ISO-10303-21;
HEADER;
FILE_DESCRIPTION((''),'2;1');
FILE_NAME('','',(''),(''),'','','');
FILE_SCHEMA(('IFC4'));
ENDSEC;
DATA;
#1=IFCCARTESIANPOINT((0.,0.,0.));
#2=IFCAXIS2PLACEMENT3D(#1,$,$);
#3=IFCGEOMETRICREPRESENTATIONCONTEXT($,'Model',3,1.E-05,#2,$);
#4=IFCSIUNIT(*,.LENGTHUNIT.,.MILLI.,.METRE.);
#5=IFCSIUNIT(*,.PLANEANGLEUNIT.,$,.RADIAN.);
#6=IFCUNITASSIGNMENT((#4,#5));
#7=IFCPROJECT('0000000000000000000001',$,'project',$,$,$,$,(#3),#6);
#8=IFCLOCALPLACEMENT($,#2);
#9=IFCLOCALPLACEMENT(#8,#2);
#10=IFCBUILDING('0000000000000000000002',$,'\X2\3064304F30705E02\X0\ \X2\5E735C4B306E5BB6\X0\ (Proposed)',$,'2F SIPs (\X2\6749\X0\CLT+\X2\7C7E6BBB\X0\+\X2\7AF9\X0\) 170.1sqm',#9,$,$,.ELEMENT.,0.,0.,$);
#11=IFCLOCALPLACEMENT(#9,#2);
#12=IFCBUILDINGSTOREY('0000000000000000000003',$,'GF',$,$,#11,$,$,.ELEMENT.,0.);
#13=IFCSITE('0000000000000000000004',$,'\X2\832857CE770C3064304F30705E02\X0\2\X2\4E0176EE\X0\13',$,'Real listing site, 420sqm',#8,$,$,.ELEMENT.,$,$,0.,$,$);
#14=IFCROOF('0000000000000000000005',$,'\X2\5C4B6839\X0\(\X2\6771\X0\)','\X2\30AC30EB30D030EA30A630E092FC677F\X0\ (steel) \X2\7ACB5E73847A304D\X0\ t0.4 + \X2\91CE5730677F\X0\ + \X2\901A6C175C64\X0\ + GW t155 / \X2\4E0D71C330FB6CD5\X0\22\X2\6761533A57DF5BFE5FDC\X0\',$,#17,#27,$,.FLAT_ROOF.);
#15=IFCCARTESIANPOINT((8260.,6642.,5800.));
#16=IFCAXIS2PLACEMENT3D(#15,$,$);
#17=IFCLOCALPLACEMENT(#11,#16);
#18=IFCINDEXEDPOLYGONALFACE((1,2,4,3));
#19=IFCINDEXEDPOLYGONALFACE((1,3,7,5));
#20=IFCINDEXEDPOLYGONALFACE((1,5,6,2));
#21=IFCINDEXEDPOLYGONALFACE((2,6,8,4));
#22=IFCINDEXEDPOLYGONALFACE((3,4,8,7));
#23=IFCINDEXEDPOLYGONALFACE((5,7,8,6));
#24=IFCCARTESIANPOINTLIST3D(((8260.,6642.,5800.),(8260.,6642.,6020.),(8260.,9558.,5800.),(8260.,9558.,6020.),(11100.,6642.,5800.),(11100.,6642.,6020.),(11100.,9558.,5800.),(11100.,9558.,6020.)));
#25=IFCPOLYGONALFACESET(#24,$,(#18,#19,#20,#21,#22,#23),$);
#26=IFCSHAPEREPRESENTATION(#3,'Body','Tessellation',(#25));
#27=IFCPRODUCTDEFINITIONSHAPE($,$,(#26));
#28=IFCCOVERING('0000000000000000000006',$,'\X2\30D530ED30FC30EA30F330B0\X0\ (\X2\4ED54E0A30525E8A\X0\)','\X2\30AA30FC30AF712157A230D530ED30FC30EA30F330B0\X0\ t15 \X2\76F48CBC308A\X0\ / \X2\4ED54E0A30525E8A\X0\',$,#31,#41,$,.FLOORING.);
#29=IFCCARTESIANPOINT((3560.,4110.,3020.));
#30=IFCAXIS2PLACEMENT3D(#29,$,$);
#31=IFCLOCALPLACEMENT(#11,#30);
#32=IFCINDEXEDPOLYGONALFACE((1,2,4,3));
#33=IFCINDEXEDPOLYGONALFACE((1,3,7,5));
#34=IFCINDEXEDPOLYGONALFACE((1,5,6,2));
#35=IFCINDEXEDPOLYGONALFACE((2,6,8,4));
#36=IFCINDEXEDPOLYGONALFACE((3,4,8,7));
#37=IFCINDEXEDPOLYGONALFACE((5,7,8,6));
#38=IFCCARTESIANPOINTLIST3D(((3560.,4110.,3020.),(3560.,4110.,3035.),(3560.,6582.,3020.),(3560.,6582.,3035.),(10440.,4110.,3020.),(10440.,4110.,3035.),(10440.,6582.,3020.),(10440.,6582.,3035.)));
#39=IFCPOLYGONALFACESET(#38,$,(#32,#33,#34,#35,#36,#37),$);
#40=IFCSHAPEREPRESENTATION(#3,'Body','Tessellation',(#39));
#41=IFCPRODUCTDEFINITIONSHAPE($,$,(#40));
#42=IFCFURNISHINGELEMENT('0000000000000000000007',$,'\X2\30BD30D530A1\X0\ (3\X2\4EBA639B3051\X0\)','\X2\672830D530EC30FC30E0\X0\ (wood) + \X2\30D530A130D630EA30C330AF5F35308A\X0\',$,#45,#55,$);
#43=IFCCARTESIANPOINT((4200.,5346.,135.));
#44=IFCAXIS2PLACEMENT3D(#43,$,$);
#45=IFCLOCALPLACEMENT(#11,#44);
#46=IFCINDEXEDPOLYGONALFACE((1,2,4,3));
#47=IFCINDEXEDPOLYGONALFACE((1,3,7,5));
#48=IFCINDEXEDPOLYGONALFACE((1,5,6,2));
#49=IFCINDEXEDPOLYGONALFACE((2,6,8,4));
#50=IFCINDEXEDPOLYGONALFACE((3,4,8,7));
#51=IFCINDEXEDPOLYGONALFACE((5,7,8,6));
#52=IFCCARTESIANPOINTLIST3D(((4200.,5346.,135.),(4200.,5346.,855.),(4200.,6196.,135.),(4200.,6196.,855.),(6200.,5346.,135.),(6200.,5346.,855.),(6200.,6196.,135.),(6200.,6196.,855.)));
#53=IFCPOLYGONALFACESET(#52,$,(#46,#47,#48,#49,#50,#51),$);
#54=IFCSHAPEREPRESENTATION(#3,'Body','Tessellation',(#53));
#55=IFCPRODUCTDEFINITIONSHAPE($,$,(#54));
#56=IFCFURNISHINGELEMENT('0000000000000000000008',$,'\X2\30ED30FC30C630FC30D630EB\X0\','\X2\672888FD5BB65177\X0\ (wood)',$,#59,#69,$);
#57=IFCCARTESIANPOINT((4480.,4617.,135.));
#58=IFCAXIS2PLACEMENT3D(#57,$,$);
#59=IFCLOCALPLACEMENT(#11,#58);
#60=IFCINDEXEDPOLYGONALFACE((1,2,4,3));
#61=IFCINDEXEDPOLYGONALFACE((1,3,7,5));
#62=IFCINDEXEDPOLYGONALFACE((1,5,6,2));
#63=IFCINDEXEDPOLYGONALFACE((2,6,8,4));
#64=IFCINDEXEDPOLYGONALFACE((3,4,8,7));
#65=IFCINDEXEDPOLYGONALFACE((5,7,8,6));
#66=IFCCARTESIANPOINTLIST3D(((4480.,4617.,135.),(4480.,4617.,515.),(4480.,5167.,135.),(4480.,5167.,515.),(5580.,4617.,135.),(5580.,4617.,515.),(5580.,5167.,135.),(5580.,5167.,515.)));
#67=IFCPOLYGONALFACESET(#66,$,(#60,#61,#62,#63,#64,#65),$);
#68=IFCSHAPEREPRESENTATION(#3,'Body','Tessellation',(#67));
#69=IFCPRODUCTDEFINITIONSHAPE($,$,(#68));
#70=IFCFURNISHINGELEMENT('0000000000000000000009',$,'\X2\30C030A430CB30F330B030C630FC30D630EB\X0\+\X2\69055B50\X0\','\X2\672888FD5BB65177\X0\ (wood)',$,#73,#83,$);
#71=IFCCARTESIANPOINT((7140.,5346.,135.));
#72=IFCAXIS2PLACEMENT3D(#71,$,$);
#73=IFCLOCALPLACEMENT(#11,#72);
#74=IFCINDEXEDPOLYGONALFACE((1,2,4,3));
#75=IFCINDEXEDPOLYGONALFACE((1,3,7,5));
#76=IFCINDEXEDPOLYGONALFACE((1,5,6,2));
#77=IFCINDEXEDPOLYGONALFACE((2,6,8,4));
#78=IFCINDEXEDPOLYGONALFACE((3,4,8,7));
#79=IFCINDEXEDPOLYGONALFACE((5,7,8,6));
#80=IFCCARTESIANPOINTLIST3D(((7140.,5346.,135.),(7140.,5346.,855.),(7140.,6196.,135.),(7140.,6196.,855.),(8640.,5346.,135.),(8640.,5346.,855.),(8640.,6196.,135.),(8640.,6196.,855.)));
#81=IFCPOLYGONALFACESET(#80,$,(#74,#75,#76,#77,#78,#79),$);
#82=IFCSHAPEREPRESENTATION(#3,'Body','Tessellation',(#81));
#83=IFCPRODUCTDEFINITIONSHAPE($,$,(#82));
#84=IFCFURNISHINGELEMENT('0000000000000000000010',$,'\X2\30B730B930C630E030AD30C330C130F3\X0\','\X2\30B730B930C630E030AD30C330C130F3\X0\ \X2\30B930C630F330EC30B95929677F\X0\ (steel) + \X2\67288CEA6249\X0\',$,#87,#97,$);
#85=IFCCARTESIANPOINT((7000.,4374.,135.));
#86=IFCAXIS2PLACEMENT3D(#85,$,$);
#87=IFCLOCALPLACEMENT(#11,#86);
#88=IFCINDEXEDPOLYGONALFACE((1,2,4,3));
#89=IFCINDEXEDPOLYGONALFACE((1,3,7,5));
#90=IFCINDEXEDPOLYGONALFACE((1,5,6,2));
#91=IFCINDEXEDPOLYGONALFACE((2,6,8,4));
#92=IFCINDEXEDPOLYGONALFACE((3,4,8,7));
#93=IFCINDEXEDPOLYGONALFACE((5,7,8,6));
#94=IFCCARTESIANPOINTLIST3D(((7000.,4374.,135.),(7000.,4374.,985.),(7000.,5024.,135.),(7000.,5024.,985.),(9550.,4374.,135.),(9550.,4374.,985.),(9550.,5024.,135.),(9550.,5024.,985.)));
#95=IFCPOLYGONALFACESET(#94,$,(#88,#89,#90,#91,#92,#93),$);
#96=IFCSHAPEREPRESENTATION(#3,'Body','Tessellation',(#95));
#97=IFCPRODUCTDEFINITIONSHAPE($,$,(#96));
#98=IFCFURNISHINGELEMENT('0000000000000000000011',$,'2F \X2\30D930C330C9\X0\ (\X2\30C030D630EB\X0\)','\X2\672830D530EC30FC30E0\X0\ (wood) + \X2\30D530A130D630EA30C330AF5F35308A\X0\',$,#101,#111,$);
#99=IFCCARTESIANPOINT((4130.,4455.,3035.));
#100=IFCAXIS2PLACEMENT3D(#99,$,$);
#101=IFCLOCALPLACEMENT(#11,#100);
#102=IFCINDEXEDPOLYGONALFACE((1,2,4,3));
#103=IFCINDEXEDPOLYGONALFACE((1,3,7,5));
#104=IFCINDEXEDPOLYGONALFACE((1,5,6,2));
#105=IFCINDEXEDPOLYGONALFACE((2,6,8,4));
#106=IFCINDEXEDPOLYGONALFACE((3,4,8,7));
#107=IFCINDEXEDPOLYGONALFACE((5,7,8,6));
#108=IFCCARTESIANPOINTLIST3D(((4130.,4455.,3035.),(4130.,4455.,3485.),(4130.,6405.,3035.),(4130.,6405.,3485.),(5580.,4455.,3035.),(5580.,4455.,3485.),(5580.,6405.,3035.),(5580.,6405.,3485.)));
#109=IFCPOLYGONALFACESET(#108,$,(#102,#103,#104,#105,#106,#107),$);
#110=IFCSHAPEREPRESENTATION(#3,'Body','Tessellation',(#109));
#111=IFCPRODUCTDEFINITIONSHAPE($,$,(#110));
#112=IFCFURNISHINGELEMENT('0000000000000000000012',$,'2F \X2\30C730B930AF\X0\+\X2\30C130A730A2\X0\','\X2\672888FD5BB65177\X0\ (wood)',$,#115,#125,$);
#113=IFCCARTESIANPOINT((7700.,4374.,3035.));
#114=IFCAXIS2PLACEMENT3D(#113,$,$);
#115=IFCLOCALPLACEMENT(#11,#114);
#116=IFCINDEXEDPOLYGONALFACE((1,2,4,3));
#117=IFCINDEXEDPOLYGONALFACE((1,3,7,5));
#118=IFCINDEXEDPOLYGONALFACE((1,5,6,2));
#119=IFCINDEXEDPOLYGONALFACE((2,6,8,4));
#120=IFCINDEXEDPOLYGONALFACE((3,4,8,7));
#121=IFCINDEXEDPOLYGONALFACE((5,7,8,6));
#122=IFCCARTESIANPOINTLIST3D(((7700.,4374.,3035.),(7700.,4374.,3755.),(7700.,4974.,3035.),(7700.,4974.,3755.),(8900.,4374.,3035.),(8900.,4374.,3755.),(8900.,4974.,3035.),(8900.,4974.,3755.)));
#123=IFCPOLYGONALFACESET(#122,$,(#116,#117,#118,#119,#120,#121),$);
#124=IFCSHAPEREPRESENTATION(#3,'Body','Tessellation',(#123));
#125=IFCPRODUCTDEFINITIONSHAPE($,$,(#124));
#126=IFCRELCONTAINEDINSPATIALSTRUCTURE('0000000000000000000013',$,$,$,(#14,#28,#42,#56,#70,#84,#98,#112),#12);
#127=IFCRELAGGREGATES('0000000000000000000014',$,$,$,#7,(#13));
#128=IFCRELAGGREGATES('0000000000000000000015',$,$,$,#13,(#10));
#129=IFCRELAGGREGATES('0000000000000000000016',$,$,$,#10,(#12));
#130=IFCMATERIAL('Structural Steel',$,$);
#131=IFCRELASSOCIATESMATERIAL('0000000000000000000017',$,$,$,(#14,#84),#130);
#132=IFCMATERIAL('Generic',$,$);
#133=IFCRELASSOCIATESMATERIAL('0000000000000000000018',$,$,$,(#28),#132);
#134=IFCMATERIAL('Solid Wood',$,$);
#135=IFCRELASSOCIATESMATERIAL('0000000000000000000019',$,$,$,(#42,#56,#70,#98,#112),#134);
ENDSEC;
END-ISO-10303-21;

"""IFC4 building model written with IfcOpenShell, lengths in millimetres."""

from ifc_helpers import new_model, si_unit, frame, frame_2d, origin, place, context, project, spatial, rectangle, extrude, material, element, save


model = new_model("IFC4")

# Units and contexts
model_context = context("Model", 3, precision=1e-05, world=origin())
ifc_project = project(units=[si_unit("LENGTHUNIT", "METRE", prefix="MILLI"), si_unit("PLANEANGLEUNIT", "RADIAN")], contexts=[model_context])

# Site, building, storey
site_placement = place(None, origin())
site = spatial("IfcSite", under=ifc_project, at=site_placement, Name="茨城県つくば市2丁目13", ObjectType="Real listing site, 420sqm", CompositionType="ELEMENT", RefElevation=0.0)
building_placement = place(site_placement, origin())
building = spatial("IfcBuilding", under=site, at=building_placement, Name="つくば市 平屋の家 (Proposed)", ObjectType="2F SIPs (杉CLT+籾殻+竹) 170.1sqm", CompositionType="ELEMENT", ElevationOfRefHeight=0.0, ElevationOfTerrain=0.0)
storey_placement = place(building_placement, origin())
storey = spatial("IfcBuildingStorey", under=building, at=storey_placement, Name="GF", CompositionType="ELEMENT", Elevation=0.0)

# Shared definitions
ifc_material_1 = material(Name="Solid Wood")

# Shared definitions
ifc_material_2 = material(Name="Generic")

# Roof
ifc_material_3 = material(Name="Structural Steel")
roof_placement = place(storey_placement, frame((8260.0, 6642.0, 5800.0)))
element("IfcRoof", 1, at=roof_placement, inside=storey, material=ifc_material_3, Name="屋根(東)", Description="ガルバリウム鋼板 (steel) 立平葺き t0.4 + 野地板 + 通気層 + GW t155 / 不燃・法22条区域対応", PredefinedType="FLAT_ROOF", context=model_context, shape_type="SweptSolid", body=[
    extrude(rectangle(XDim=2840.0, YDim=2916.0, at=frame_2d((1420.0, 1458.0))), frame((8260.0, 6642.0, 5800.0)), (0.0, 0.0, 1.0), 220.0),
])

# Covering
covering_placement = place(storey_placement, frame((3560.0, 4110.0, 3020.0)))
element("IfcCovering", 2, at=covering_placement, inside=storey, material=ifc_material_2, Name="フローリング (仕上げ床)", Description="オーク無垢フローリング t15 直貼り / 仕上げ床", PredefinedType="FLOORING", context=model_context, shape_type="SweptSolid", body=[
    extrude(rectangle(XDim=6880.0, YDim=2472.0, at=frame_2d((3440.0, 1236.0))), frame((3560.0, 4110.0, 3020.0)), (0.0, 0.0, 1.0), 15.0),
])

# Furnishing elements
furnishing_1_placement = place(storey_placement, frame((4200.0, 5346.0, 135.0)))
element("IfcFurnishingElement", 3, at=furnishing_1_placement, inside=storey, material=ifc_material_1, Name="ソファ (3人掛け)", Description="木フレーム (wood) + ファブリック張り", context=model_context, shape_type="SweptSolid", body=[
    extrude(rectangle(XDim=2000.0, YDim=850.0, at=frame_2d((1000.0, 425.0))), frame((4200.0, 5346.0, 135.0)), (0.0, 0.0, 1.0), 720.0),
])
furnishing_2_placement = place(storey_placement, frame((4480.0, 4617.0, 135.0)))
element("IfcFurnishingElement", 4, at=furnishing_2_placement, inside=storey, material=ifc_material_1, Name="ローテーブル", Description="木製家具 (wood)", context=model_context, shape_type="SweptSolid", body=[
    extrude(rectangle(XDim=1100.0, YDim=550.0, at=frame_2d((550.0, 275.0))), frame((4480.0, 4617.0, 135.0)), (0.0, 0.0, 1.0), 380.0),
])
furnishing_3_placement = place(storey_placement, frame((7140.0, 5346.0, 135.0)))
element("IfcFurnishingElement", 5, at=furnishing_3_placement, inside=storey, material=ifc_material_1, Name="ダイニングテーブル+椅子", Description="木製家具 (wood)", context=model_context, shape_type="SweptSolid", body=[
    extrude(rectangle(XDim=1500.0, YDim=850.0, at=frame_2d((750.0, 425.0))), frame((7140.0, 5346.0, 135.0)), (0.0, 0.0, 1.0), 720.0),
])
furnishing_4_placement = place(storey_placement, frame((7000.0, 4374.0, 135.0)))
element("IfcFurnishingElement", 6, at=furnishing_4_placement, inside=storey, material=ifc_material_3, Name="システムキッチン", Description="システムキッチン ステンレス天板 (steel) + 木質扉", context=model_context, shape_type="SweptSolid", body=[
    extrude(rectangle(XDim=2550.0, YDim=650.0, at=frame_2d((1275.0, 325.0))), frame((7000.0, 4374.0, 135.0)), (0.0, 0.0, 1.0), 850.0),
])
furnishing_5_placement = place(storey_placement, frame((4130.0, 4455.0, 3035.0)))
element("IfcFurnishingElement", 7, at=furnishing_5_placement, inside=storey, material=ifc_material_1, Name="2F ベッド (ダブル)", Description="木フレーム (wood) + ファブリック張り", context=model_context, shape_type="SweptSolid", body=[
    extrude(rectangle(XDim=1450.0, YDim=1950.0, at=frame_2d((725.0, 975.0))), frame((4130.0, 4455.0, 3035.0)), (0.0, 0.0, 1.0), 450.0),
])
furnishing_6_placement = place(storey_placement, frame((7700.0, 4374.0, 3035.0)))
element("IfcFurnishingElement", 8, at=furnishing_6_placement, inside=storey, material=ifc_material_1, Name="2F デスク+チェア", Description="木製家具 (wood)", context=model_context, shape_type="SweptSolid", body=[
    extrude(rectangle(XDim=1200.0, YDim=600.0, at=frame_2d((600.0, 300.0))), frame((7700.0, 4374.0, 3035.0)), (0.0, 0.0, 1.0), 720.0),
])

save(model, "model.ifc")
